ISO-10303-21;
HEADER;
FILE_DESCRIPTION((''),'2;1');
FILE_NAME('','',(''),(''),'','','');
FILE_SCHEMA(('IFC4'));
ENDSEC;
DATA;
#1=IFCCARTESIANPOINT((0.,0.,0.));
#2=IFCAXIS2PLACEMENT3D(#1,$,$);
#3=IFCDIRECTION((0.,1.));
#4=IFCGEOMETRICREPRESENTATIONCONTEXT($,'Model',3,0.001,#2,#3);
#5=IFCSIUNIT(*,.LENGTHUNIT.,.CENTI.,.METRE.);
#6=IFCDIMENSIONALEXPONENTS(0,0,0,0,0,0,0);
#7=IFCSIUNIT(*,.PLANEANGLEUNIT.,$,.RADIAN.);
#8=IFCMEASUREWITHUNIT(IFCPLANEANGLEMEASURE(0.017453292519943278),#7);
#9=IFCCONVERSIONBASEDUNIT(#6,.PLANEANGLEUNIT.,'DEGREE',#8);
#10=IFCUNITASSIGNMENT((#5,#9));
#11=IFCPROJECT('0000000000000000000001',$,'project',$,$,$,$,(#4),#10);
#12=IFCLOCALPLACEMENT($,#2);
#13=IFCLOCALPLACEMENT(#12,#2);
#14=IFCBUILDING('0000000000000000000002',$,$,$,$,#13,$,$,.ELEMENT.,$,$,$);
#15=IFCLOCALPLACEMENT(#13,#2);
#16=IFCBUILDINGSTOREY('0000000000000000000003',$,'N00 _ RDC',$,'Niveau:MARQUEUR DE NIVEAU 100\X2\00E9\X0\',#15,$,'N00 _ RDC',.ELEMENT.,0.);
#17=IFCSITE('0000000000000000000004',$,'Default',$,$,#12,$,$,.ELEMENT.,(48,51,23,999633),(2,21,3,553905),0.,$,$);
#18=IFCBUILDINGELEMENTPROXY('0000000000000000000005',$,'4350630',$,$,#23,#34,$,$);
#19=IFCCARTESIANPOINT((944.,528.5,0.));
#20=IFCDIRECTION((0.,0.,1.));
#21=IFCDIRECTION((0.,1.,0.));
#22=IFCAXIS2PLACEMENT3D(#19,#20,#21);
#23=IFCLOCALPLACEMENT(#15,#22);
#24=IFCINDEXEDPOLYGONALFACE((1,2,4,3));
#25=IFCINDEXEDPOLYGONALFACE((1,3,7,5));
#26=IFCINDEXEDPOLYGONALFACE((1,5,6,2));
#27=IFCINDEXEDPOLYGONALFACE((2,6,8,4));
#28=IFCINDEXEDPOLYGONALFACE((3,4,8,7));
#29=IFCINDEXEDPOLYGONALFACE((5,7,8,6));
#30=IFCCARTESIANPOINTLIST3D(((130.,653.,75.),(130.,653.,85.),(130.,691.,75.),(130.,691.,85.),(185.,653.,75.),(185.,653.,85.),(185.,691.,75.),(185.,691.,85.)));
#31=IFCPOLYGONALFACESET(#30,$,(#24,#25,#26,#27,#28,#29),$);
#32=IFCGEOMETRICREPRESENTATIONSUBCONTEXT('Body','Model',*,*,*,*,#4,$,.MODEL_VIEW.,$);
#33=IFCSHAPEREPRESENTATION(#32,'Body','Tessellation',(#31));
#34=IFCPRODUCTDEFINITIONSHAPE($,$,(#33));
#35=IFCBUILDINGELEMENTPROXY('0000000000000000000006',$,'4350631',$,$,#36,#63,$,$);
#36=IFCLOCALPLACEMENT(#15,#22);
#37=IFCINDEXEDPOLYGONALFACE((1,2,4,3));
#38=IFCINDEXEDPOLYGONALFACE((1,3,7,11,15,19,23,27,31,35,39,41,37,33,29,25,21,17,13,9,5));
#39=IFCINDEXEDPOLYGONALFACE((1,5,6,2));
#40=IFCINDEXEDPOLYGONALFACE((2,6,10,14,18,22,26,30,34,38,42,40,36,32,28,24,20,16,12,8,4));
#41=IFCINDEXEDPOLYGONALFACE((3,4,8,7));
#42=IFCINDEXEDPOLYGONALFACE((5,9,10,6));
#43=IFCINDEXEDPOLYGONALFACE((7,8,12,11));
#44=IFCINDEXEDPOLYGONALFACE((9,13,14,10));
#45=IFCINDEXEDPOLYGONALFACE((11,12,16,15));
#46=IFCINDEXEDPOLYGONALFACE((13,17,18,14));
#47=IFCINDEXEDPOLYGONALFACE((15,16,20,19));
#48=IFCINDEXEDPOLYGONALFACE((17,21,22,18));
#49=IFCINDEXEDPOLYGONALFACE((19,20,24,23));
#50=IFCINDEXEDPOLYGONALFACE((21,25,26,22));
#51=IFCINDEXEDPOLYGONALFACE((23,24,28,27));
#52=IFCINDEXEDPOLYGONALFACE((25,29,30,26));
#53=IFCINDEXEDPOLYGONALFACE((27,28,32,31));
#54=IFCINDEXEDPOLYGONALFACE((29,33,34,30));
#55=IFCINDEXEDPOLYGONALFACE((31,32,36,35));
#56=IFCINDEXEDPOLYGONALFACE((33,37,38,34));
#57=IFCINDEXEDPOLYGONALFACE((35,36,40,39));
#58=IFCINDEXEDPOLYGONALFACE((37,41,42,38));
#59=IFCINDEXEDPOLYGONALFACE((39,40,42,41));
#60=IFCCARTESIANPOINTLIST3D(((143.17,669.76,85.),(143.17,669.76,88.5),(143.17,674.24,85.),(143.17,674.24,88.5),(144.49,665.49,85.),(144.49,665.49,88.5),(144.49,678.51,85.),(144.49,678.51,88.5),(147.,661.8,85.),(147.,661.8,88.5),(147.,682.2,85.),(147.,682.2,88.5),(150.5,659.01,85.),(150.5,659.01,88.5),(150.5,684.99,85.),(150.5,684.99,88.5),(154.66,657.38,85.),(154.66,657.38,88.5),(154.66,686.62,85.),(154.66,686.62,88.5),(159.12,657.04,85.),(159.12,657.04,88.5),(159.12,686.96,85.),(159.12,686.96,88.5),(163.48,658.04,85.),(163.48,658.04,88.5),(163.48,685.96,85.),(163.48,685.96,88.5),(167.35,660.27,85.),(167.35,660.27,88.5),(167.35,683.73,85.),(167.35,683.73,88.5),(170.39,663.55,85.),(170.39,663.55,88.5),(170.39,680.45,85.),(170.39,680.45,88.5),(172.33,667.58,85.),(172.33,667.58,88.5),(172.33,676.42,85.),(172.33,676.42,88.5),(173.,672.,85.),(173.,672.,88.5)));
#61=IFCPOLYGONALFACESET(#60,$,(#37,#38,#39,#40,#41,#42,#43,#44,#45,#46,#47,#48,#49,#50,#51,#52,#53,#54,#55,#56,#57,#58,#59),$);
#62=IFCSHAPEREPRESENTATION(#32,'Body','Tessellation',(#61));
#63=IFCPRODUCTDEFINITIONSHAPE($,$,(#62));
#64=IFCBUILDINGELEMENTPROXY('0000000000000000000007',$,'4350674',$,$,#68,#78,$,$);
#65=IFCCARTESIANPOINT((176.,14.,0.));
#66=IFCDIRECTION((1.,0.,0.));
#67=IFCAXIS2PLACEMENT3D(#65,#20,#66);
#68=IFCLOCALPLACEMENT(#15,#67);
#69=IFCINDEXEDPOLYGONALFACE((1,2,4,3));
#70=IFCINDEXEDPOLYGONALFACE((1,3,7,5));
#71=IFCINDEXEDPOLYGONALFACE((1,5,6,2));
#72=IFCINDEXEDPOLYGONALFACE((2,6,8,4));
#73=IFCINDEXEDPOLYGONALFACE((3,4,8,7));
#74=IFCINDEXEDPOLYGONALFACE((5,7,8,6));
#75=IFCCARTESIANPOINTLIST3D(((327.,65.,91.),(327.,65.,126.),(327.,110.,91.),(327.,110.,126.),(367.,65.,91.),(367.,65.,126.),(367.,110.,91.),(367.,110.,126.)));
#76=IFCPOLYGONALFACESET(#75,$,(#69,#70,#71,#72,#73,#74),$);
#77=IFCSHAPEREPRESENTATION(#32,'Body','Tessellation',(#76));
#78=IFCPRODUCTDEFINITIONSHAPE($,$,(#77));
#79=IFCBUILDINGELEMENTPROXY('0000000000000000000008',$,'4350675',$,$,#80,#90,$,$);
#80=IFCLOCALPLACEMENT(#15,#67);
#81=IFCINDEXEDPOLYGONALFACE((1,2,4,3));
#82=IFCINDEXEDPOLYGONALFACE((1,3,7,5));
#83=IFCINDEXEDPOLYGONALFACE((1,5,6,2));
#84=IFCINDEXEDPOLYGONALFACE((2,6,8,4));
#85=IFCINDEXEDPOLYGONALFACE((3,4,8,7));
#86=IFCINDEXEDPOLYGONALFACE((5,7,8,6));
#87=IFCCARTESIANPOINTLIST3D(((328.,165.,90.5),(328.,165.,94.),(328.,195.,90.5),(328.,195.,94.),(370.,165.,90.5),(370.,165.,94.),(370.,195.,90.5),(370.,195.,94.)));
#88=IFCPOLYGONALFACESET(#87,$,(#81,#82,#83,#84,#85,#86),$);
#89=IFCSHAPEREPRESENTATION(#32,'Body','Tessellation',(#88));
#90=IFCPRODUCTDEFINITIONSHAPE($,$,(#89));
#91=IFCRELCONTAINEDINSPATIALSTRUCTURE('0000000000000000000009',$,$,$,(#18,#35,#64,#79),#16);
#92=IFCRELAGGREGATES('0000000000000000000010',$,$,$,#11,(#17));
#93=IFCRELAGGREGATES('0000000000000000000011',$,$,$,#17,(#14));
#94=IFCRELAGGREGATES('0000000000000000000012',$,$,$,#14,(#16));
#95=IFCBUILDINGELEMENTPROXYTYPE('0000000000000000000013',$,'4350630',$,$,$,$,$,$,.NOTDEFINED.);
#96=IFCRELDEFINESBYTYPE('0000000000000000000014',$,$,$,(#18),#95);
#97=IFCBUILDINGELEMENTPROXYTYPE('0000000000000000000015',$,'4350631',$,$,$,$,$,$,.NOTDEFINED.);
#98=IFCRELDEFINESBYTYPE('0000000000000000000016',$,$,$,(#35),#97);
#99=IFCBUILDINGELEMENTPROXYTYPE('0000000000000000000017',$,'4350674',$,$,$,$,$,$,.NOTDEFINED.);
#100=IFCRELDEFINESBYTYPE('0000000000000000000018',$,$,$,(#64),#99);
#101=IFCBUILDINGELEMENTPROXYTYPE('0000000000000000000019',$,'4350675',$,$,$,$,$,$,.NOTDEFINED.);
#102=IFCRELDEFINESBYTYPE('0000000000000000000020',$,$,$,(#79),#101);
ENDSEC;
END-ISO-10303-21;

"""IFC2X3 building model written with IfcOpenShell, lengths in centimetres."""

from ifc_helpers import new_model, entity, si_unit, converted_unit, direction, frame, origin, origin_2d_with_axis, place, context, subcontext, project, spatial, rectangle, circle, extrude, type_object, element, save


model = new_model("IFC2X3")

# Units and contexts
model_context = context("Model", 3, precision=0.001, world=origin(), true_north=direction((0.0, 1.0)))
body_context = subcontext(model_context, "Body", "Model", "MODEL_VIEW")
ifc_project = project(units=[si_unit("LENGTHUNIT", "METRE", prefix="CENTI"), converted_unit("PLANEANGLEUNIT", "DEGREE", entity("IfcPlaneAngleMeasure", 0.017453292519943278), si_unit("PLANEANGLEUNIT", "RADIAN"), dimensions=[0, 0, 0, 0, 0, 0, 0])], contexts=[model_context])

# Site, building, storey
site_placement = place(None, origin())
site = spatial("IfcSite", under=ifc_project, at=site_placement, Name="Default", CompositionType="ELEMENT", RefLatitude=(48, 51, 23, 999633), RefLongitude=(2, 21, 3, 553905), RefElevation=0.0)
building_placement = place(site_placement, origin())
building = spatial("IfcBuilding", under=site, at=building_placement, CompositionType="ELEMENT")
storey_placement = place(building_placement, origin())
storey = spatial("IfcBuildingStorey", under=building, at=storey_placement, Name="N00 _ RDC", ObjectType="Niveau:MARQUEUR DE NIVEAU 100é", LongName="N00 _ RDC", CompositionType="ELEMENT", Elevation=0.0)

# Building element proxies
building_element_proxy_type_1 = type_object("IfcBuildingElementProxyType", Name="4350630", PredefinedType="NOTDEFINED")
proxy_1_placement = place(storey_placement, frame((944.0, 528.5, 0.0), z_axis=(0.0, 0.0, 1.0), x_axis=(0.0, 1.0, 0.0)))
element("IfcBuildingElementProxy", 1, at=proxy_1_placement, inside=storey, type_object=building_element_proxy_type_1, Name="4350630", context=body_context, shape_type="SweptSolid", body=[
    extrude(rectangle(XDim=55.0, YDim=38.0, at=origin_2d_with_axis()), frame((157.5, 672.0, 75.0)), (0.0, 0.0, 1.0), 10.0),
])
building_element_proxy_type_2 = type_object("IfcBuildingElementProxyType", Name="4350631", PredefinedType="NOTDEFINED")
proxy_2_placement = place(storey_placement, frame((944.0, 528.5, 0.0), z_axis=(0.0, 0.0, 1.0), x_axis=(0.0, 1.0, 0.0)))
element("IfcBuildingElementProxy", 2, at=proxy_2_placement, inside=storey, type_object=building_element_proxy_type_2, Name="4350631", context=body_context, shape_type="SweptSolid", body=[
    extrude(circle(Radius=15.0, at=origin_2d_with_axis()), frame((158.0, 672.0, 85.0)), (0.0, 0.0, 1.0), 3.5),
])
building_element_proxy_type_3 = type_object("IfcBuildingElementProxyType", Name="4350674", PredefinedType="NOTDEFINED")
proxy_3_placement = place(storey_placement, frame((176.0, 14.0, 0.0), z_axis=(0.0, 0.0, 1.0), x_axis=(1.0, 0.0, 0.0)))
element("IfcBuildingElementProxy", 3, at=proxy_3_placement, inside=storey, type_object=building_element_proxy_type_3, Name="4350674", context=body_context, shape_type="SweptSolid", body=[
    extrude(rectangle(XDim=40.0, YDim=45.0, at=origin_2d_with_axis()), frame((347.0, 87.5, 91.0)), (0.0, 0.0, 1.0), 35.0),
])
building_element_proxy_type_4 = type_object("IfcBuildingElementProxyType", Name="4350675", PredefinedType="NOTDEFINED")
proxy_4_placement = place(storey_placement, frame((176.0, 14.0, 0.0), z_axis=(0.0, 0.0, 1.0), x_axis=(1.0, 0.0, 0.0)))
element("IfcBuildingElementProxy", 4, at=proxy_4_placement, inside=storey, type_object=building_element_proxy_type_4, Name="4350675", context=body_context, shape_type="SweptSolid", body=[
    extrude(rectangle(XDim=42.0, YDim=30.0, at=origin_2d_with_axis()), frame((349.0, 180.0, 90.5)), (0.0, 0.0, 1.0), 3.5),
])

save(model, "model.ifc")
